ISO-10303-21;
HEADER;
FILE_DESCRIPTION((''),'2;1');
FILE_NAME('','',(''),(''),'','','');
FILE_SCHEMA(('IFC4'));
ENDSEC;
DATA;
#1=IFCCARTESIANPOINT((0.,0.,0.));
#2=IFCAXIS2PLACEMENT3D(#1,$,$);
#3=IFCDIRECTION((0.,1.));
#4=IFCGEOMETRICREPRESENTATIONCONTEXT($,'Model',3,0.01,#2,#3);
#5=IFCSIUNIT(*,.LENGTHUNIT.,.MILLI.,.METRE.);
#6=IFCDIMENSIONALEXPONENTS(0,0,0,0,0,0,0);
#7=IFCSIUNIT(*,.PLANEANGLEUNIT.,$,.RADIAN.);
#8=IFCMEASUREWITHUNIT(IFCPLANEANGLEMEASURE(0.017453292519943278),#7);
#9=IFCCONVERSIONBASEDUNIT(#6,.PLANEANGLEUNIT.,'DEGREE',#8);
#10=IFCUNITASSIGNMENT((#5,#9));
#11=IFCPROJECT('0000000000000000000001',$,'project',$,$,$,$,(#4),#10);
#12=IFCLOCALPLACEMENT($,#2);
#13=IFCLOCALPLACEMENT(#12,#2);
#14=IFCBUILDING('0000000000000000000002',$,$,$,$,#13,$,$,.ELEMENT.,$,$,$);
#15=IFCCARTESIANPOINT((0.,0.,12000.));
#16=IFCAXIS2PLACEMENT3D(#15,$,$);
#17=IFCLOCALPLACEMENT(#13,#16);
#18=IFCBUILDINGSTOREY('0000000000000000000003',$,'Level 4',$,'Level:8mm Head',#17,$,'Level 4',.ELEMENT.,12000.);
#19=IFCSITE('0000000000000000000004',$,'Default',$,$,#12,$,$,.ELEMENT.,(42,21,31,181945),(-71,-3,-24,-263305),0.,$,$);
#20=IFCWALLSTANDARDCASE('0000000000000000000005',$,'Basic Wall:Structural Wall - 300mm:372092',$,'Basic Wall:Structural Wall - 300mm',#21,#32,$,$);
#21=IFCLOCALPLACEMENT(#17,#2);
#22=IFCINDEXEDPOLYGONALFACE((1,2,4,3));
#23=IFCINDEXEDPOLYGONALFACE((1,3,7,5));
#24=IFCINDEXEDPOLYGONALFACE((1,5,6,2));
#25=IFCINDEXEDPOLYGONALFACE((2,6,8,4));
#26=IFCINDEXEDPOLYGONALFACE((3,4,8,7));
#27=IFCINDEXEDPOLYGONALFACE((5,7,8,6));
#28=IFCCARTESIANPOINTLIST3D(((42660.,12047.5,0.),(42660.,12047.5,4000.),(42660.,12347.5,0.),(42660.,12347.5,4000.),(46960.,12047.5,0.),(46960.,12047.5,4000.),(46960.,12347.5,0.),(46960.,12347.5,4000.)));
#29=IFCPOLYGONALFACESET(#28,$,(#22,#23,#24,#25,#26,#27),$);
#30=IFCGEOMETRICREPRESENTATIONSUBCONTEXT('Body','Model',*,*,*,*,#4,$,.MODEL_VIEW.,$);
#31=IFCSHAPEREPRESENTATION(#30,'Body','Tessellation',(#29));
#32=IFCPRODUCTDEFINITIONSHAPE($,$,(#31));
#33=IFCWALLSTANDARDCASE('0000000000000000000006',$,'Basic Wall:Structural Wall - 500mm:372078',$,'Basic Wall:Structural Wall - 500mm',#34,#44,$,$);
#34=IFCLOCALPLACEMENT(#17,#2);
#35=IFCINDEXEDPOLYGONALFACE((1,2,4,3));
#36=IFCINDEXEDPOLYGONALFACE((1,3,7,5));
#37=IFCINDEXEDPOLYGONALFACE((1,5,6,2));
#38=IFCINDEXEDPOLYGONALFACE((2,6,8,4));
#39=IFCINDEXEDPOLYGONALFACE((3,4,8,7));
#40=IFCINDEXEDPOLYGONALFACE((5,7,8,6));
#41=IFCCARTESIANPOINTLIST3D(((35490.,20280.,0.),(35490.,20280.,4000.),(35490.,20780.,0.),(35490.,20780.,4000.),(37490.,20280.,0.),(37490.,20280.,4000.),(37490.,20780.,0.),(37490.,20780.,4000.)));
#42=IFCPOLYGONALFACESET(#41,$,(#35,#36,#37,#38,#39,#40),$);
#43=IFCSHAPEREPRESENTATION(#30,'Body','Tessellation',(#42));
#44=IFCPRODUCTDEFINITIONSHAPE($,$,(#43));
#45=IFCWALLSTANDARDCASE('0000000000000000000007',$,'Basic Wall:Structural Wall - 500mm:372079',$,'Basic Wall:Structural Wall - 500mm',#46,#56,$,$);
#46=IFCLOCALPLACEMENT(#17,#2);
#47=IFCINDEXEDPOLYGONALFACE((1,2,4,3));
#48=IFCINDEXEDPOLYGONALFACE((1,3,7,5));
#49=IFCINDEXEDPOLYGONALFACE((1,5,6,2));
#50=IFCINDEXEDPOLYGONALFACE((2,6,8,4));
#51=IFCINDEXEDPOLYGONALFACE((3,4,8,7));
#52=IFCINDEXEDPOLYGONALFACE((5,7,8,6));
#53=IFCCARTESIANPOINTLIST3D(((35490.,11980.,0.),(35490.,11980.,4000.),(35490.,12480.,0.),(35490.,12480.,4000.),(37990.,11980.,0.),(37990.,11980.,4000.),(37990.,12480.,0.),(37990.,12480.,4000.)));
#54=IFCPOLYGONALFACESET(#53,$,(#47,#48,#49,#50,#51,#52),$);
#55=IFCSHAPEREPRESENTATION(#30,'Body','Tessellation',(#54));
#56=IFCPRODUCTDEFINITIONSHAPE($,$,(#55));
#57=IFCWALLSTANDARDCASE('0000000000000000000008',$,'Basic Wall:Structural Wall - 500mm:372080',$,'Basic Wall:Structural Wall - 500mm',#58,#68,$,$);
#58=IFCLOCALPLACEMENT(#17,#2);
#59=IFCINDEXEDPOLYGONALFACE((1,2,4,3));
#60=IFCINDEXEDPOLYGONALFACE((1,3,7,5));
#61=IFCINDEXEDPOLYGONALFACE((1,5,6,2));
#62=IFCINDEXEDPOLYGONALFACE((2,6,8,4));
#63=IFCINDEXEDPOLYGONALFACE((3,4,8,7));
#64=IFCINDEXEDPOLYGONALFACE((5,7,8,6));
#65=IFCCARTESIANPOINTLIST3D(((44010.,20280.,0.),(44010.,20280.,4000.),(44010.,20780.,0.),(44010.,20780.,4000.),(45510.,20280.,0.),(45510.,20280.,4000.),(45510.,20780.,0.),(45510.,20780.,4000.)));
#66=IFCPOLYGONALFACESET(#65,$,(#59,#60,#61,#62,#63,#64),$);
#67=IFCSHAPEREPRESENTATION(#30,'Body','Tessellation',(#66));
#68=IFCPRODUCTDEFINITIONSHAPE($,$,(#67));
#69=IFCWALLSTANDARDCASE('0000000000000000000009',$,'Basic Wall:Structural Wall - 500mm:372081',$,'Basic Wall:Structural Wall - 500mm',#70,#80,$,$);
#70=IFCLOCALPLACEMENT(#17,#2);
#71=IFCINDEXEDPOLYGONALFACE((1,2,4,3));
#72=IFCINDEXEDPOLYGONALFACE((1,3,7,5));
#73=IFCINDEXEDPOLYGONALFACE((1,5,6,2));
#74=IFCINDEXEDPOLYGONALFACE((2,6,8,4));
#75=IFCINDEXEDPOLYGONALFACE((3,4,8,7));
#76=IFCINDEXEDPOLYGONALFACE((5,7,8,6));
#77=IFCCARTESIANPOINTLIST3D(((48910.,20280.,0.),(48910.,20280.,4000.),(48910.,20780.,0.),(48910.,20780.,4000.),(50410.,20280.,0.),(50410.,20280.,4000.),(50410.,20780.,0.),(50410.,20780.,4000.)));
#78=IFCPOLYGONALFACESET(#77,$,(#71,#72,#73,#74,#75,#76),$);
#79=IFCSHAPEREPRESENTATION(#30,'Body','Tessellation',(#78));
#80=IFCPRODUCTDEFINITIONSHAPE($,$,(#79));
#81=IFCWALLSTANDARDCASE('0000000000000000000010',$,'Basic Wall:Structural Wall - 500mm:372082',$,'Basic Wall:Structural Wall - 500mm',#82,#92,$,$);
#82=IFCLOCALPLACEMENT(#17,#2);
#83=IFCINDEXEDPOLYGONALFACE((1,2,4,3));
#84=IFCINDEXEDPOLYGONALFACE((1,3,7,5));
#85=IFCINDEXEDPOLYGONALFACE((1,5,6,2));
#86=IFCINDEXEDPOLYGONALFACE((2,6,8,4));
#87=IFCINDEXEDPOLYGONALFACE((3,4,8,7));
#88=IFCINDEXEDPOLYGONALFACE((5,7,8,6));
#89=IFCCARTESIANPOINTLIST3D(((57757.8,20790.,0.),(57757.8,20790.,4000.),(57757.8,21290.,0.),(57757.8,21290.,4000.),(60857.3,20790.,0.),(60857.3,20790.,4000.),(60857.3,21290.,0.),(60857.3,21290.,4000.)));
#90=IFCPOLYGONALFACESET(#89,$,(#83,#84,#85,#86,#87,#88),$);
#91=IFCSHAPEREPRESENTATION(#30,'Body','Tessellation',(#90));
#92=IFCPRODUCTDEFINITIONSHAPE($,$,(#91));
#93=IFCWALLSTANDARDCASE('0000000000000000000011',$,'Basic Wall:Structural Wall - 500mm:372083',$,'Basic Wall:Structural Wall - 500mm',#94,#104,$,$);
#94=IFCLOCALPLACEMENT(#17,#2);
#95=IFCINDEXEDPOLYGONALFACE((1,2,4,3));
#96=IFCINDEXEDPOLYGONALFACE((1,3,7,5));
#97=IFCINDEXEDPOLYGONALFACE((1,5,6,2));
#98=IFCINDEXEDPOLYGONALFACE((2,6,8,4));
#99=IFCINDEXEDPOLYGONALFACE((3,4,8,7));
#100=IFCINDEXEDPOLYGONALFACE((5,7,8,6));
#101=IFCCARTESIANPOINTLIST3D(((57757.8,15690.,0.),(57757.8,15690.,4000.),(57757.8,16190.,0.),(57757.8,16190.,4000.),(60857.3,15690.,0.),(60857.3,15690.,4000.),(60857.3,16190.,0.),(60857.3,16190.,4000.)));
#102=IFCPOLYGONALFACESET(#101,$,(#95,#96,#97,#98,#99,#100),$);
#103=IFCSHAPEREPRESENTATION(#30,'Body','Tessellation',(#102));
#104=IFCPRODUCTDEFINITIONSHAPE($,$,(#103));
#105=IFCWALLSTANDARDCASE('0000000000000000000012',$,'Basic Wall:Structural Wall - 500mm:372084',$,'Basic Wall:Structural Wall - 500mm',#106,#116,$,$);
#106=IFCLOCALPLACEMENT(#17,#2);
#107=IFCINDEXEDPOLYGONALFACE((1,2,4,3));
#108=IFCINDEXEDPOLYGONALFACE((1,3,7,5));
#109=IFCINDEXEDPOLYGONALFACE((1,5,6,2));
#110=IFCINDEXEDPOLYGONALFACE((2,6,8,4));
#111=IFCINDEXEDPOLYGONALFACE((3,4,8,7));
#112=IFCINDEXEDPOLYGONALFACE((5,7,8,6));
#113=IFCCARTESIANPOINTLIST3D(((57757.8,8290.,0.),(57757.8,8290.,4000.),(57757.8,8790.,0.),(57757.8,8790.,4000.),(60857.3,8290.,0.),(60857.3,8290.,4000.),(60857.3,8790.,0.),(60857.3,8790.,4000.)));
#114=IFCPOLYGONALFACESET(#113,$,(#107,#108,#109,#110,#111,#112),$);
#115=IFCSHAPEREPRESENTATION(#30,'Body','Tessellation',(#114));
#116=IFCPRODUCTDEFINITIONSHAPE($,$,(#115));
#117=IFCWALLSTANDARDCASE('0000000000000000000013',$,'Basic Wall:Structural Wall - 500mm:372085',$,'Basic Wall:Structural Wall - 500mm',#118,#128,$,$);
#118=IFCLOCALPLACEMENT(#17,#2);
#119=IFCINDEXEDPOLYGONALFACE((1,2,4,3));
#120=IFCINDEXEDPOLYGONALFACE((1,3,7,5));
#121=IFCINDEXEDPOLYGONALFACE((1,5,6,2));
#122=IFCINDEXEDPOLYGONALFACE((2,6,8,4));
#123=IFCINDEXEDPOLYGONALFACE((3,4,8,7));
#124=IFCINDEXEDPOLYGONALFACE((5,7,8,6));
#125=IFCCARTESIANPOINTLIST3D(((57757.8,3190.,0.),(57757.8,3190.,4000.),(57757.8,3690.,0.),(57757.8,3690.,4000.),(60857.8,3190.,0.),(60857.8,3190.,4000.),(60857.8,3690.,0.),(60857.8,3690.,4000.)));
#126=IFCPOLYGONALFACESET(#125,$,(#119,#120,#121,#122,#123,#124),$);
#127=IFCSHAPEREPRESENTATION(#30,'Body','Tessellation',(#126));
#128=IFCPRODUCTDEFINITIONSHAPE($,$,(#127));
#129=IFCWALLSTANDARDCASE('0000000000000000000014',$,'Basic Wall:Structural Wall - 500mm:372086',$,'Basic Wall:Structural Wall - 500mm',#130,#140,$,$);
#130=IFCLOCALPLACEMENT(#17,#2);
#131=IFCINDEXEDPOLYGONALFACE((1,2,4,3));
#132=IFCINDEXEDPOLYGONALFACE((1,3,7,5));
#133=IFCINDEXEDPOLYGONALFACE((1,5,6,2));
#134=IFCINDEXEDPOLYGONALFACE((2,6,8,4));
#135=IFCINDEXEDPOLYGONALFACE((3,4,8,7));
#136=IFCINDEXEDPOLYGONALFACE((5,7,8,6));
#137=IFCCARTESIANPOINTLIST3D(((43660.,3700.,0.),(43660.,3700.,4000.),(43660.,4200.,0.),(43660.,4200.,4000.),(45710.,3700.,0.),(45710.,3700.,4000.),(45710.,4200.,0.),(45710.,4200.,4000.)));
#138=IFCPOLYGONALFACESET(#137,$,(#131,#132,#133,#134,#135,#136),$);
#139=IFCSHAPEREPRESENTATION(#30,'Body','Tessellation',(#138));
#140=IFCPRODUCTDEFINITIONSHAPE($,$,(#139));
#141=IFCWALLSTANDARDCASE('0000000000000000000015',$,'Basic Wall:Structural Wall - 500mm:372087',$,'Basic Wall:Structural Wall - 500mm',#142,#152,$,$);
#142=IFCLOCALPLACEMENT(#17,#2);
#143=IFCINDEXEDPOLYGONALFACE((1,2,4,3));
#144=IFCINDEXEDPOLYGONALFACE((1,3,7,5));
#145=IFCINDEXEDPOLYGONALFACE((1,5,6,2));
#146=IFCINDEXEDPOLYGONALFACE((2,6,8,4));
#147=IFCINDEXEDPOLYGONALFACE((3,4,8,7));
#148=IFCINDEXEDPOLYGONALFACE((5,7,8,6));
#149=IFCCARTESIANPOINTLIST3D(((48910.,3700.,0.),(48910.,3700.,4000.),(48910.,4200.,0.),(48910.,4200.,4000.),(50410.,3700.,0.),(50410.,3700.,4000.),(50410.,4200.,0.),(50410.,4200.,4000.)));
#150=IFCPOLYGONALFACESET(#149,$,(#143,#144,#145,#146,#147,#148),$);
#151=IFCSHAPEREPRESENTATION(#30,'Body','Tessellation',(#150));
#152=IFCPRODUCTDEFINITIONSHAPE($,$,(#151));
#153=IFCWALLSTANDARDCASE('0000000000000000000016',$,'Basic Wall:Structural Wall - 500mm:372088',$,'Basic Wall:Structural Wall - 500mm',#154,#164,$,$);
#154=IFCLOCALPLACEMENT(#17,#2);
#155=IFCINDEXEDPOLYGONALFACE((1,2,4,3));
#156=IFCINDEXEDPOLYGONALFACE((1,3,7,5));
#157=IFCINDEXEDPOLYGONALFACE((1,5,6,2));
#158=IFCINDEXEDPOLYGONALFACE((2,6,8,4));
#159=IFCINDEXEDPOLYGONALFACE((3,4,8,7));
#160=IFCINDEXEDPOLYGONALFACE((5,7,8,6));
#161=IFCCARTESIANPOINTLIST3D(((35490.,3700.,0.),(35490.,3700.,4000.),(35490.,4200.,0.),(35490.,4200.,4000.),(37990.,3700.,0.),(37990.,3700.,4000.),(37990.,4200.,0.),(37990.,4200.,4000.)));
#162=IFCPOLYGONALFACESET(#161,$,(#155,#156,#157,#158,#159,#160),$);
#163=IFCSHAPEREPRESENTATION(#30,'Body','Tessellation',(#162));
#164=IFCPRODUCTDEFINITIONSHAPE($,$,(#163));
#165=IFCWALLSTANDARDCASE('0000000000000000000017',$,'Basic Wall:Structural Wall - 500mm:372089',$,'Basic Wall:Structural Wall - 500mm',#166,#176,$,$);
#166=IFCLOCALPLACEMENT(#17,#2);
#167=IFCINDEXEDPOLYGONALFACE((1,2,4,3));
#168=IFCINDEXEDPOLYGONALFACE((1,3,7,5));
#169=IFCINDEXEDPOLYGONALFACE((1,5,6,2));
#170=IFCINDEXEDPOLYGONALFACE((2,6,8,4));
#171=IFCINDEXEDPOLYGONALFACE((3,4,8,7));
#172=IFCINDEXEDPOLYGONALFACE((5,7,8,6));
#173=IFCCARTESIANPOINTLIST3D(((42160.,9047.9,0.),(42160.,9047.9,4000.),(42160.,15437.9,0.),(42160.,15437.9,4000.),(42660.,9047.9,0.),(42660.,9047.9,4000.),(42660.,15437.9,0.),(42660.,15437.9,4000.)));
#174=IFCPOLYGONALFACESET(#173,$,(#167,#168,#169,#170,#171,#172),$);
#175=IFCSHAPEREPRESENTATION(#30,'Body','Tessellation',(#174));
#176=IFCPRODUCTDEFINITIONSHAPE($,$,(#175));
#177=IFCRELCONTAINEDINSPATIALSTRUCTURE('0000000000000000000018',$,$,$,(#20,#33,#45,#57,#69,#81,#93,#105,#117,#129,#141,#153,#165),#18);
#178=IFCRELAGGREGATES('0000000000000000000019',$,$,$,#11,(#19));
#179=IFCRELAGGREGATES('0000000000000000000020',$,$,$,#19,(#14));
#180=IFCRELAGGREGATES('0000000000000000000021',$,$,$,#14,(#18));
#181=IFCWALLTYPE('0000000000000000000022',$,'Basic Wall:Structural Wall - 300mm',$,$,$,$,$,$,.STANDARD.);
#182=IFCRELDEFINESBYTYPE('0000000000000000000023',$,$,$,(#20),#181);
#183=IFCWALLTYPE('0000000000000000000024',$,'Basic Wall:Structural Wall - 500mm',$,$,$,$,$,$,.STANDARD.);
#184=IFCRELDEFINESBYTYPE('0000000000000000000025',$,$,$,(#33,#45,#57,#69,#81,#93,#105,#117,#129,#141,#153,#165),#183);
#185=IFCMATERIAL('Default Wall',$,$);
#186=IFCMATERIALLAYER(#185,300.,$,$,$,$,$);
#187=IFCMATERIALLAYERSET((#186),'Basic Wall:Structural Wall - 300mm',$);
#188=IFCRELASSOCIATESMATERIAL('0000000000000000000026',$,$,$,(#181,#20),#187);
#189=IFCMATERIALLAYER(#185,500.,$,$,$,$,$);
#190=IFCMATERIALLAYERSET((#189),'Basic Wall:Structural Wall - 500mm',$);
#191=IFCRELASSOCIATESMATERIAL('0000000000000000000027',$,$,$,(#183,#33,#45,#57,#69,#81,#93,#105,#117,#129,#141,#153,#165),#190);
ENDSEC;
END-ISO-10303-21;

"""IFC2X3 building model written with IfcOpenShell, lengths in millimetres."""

from ifc_helpers import new_model, entity, si_unit, converted_unit, direction, frame, frame_2d, origin, place, context, subcontext, project, spatial, rectangle, extrude, material, layer, layer_set, layer_usage, type_object, element, save


model = new_model("IFC2X3")

# Units and contexts
model_context = context("Model", 3, precision=0.01, world=origin(), true_north=direction((0.0, 1.0)))
body_context = subcontext(model_context, "Body", "Model", "MODEL_VIEW")
ifc_project = project(units=[si_unit("LENGTHUNIT", "METRE", prefix="MILLI"), converted_unit("PLANEANGLEUNIT", "DEGREE", entity("IfcPlaneAngleMeasure", 0.017453292519943278), si_unit("PLANEANGLEUNIT", "RADIAN"), dimensions=[0, 0, 0, 0, 0, 0, 0])], contexts=[model_context])

# Site, building, storey
site_placement = place(None, origin())
site = spatial("IfcSite", under=ifc_project, at=site_placement, Name="Default", CompositionType="ELEMENT", RefLatitude=(42, 21, 31, 181945), RefLongitude=(-71, -3, -24, -263305), RefElevation=0.0)
building_placement = place(site_placement, origin())
building = spatial("IfcBuilding", under=site, at=building_placement, CompositionType="ELEMENT")
storey_placement = place(building_placement, frame((0.0, 0.0, 12000.0)))
storey = spatial("IfcBuildingStorey", under=building, at=storey_placement, Name="Level 4", ObjectType="Level:8mm Head", LongName="Level 4", CompositionType="ELEMENT", Elevation=12000.0)

# Walls
ifc_material = material(Name="Default Wall")
ifc_layer_1 = layer(ifc_material, 300.0)
ifc_layer_set_1 = layer_set([ifc_layer_1], Name="Basic Wall:Structural Wall - 300mm")
ifc_layer_usage_1 = layer_usage(ifc_layer_set_1, "AXIS2", "NEGATIVE", 150.0)
wall_type_1 = type_object("IfcWallType", Name="Basic Wall:Structural Wall - 300mm", PredefinedType="STANDARD", material=ifc_layer_set_1)
wall_1_placement = place(storey_placement, frame((42660.0, 12197.5, 0.0)))
element("IfcWallStandardCase", 1, at=wall_1_placement, inside=storey, type_object=wall_type_1, material=ifc_layer_usage_1, Name="Basic Wall:Structural Wall - 300mm:372092", ObjectType="Basic Wall:Structural Wall - 300mm", context=body_context, shape_type="SweptSolid", body=[
    extrude(rectangle(XDim=4300.0, YDim=300.0, at=frame_2d((2150.0, 0.0), x_axis=(-1.0, 0.0))), origin(), (0.0, 0.0, 1.0), 4000.0),
])
ifc_layer_2 = layer(ifc_material, 500.0)
ifc_layer_set_2 = layer_set([ifc_layer_2], Name="Basic Wall:Structural Wall - 500mm")
ifc_layer_usage_2 = layer_usage(ifc_layer_set_2, "AXIS2", "NEGATIVE", 250.0)
wall_type_2 = type_object("IfcWallType", Name="Basic Wall:Structural Wall - 500mm", PredefinedType="STANDARD", material=ifc_layer_set_2)
wall_2_placement = place(storey_placement, frame((35490.0, 20530.0, 0.0)))
element("IfcWallStandardCase", 2, at=wall_2_placement, inside=storey, type_object=wall_type_2, material=ifc_layer_usage_2, Name="Basic Wall:Structural Wall - 500mm:372078", ObjectType="Basic Wall:Structural Wall - 500mm", context=body_context, shape_type="SweptSolid", body=[
    extrude(rectangle(XDim=2000.0, YDim=500.0, at=frame_2d((1000.0, 0.0), x_axis=(-1.0, 0.0))), origin(), (0.0, 0.0, 1.0), 4000.0),
])
ifc_layer_usage_3 = layer_usage(ifc_layer_set_2, "AXIS2", "NEGATIVE", 250.0)
wall_3_placement = place(storey_placement, frame((35490.0, 12230.0, 0.0)))
element("IfcWallStandardCase", 3, at=wall_3_placement, inside=storey, type_object=wall_type_2, material=ifc_layer_usage_3, Name="Basic Wall:Structural Wall - 500mm:372079", ObjectType="Basic Wall:Structural Wall - 500mm", context=body_context, shape_type="SweptSolid", body=[
    extrude(rectangle(XDim=2500.0, YDim=500.0, at=frame_2d((1250.0, 0.0), x_axis=(-1.0, 0.0))), origin(), (0.0, 0.0, 1.0), 4000.0),
])
ifc_layer_usage_4 = layer_usage(ifc_layer_set_2, "AXIS2", "NEGATIVE", 250.0)
wall_4_placement = place(storey_placement, frame((44010.0, 20530.0, 0.0)))
element("IfcWallStandardCase", 4, at=wall_4_placement, inside=storey, type_object=wall_type_2, material=ifc_layer_usage_4, Name="Basic Wall:Structural Wall - 500mm:372080", ObjectType="Basic Wall:Structural Wall - 500mm", context=body_context, shape_type="SweptSolid", body=[
    extrude(rectangle(XDim=1500.0, YDim=500.0, at=frame_2d((750.0, 0.0), x_axis=(-1.0, 0.0))), origin(), (0.0, 0.0, 1.0), 4000.0),
])
ifc_layer_usage_5 = layer_usage(ifc_layer_set_2, "AXIS2", "NEGATIVE", 250.0)
wall_5_placement = place(storey_placement, frame((48910.0, 20530.0, 0.0)))
element("IfcWallStandardCase", 5, at=wall_5_placement, inside=storey, type_object=wall_type_2, material=ifc_layer_usage_5, Name="Basic Wall:Structural Wall - 500mm:372081", ObjectType="Basic Wall:Structural Wall - 500mm", context=body_context, shape_type="SweptSolid", body=[
    extrude(rectangle(XDim=1500.0, YDim=500.0, at=frame_2d((750.0, 0.0), x_axis=(-1.0, 0.0))), origin(), (0.0, 0.0, 1.0), 4000.0),
])
ifc_layer_usage_6 = layer_usage(ifc_layer_set_2, "AXIS2", "NEGATIVE", 250.0)
wall_6_placement = place(storey_placement, frame((57757.8, 21040.0, 0.0)))
element("IfcWallStandardCase", 6, at=wall_6_placement, inside=storey, type_object=wall_type_2, material=ifc_layer_usage_6, Name="Basic Wall:Structural Wall - 500mm:372082", ObjectType="Basic Wall:Structural Wall - 500mm", context=body_context, shape_type="SweptSolid", body=[
    extrude(rectangle(XDim=3099.5, YDim=500.0, at=frame_2d((1549.8, 0.0), x_axis=(-1.0, 0.0))), origin(), (0.0, 0.0, 1.0), 4000.0),
])
ifc_layer_usage_7 = layer_usage(ifc_layer_set_2, "AXIS2", "NEGATIVE", 250.0)
wall_7_placement = place(storey_placement, frame((57757.8, 15940.0, 0.0)))
element("IfcWallStandardCase", 7, at=wall_7_placement, inside=storey, type_object=wall_type_2, material=ifc_layer_usage_7, Name="Basic Wall:Structural Wall - 500mm:372083", ObjectType="Basic Wall:Structural Wall - 500mm", context=body_context, shape_type="SweptSolid", body=[
    extrude(rectangle(XDim=3099.5, YDim=500.0, at=frame_2d((1549.8, 0.0), x_axis=(-1.0, 0.0))), origin(), (0.0, 0.0, 1.0), 4000.0),
])
ifc_layer_usage_8 = layer_usage(ifc_layer_set_2, "AXIS2", "NEGATIVE", 250.0)
wall_8_placement = place(storey_placement, frame((57757.8, 8540.0, 0.0)))
element("IfcWallStandardCase", 8, at=wall_8_placement, inside=storey, type_object=wall_type_2, material=ifc_layer_usage_8, Name="Basic Wall:Structural Wall - 500mm:372084", ObjectType="Basic Wall:Structural Wall - 500mm", context=body_context, shape_type="SweptSolid", body=[
    extrude(rectangle(XDim=3099.5, YDim=500.0, at=frame_2d((1549.8, 0.0), x_axis=(-1.0, 0.0))), origin(), (0.0, 0.0, 1.0), 4000.0),
])
ifc_layer_usage_9 = layer_usage(ifc_layer_set_2, "AXIS2", "NEGATIVE", 250.0)
wall_9_placement = place(storey_placement, frame((57757.8, 3440.0, 0.0)))
element("IfcWallStandardCase", 9, at=wall_9_placement, inside=storey, type_object=wall_type_2, material=ifc_layer_usage_9, Name="Basic Wall:Structural Wall - 500mm:372085", ObjectType="Basic Wall:Structural Wall - 500mm", context=body_context, shape_type="SweptSolid", body=[
    extrude(rectangle(XDim=3100.0, YDim=500.0, at=frame_2d((1550.0, 0.0), x_axis=(-1.0, 0.0))), origin(), (0.0, 0.0, 1.0), 4000.0),
])
ifc_layer_usage_10 = layer_usage(ifc_layer_set_2, "AXIS2", "NEGATIVE", 250.0)
wall_10_placement = place(storey_placement, frame((43660.0, 3950.0, 0.0)))
element("IfcWallStandardCase", 10, at=wall_10_placement, inside=storey, type_object=wall_type_2, material=ifc_layer_usage_10, Name="Basic Wall:Structural Wall - 500mm:372086", ObjectType="Basic Wall:Structural Wall - 500mm", context=body_context, shape_type="SweptSolid", body=[
    extrude(rectangle(XDim=2050.0, YDim=500.0, at=frame_2d((1025.0, 0.0), x_axis=(-1.0, 0.0))), origin(), (0.0, 0.0, 1.0), 4000.0),
])
ifc_layer_usage_11 = layer_usage(ifc_layer_set_2, "AXIS2", "NEGATIVE", 250.0)
wall_11_placement = place(storey_placement, frame((48910.0, 3950.0, 0.0)))
element("IfcWallStandardCase", 11, at=wall_11_placement, inside=storey, type_object=wall_type_2, material=ifc_layer_usage_11, Name="Basic Wall:Structural Wall - 500mm:372087", ObjectType="Basic Wall:Structural Wall - 500mm", context=body_context, shape_type="SweptSolid", body=[
    extrude(rectangle(XDim=1500.0, YDim=500.0, at=frame_2d((750.0, 0.0), x_axis=(-1.0, 0.0))), origin(), (0.0, 0.0, 1.0), 4000.0),
])
ifc_layer_usage_12 = layer_usage(ifc_layer_set_2, "AXIS2", "NEGATIVE", 250.0)
wall_12_placement = place(storey_placement, frame((35490.0, 3950.0, 0.0)))
element("IfcWallStandardCase", 12, at=wall_12_placement, inside=storey, type_object=wall_type_2, material=ifc_layer_usage_12, Name="Basic Wall:Structural Wall - 500mm:372088", ObjectType="Basic Wall:Structural Wall - 500mm", context=body_context, shape_type="SweptSolid", body=[
    extrude(rectangle(XDim=2500.0, YDim=500.0, at=frame_2d((1250.0, 0.0), x_axis=(-1.0, 0.0))), origin(), (0.0, 0.0, 1.0), 4000.0),
])
ifc_layer_usage_13 = layer_usage(ifc_layer_set_2, "AXIS2", "NEGATIVE", 250.0)
wall_13_placement = place(storey_placement, frame((42410.0, 15437.9, 0.0), z_axis=(0.0, 0.0, 1.0), x_axis=(0.0, -1.0, 0.0)))
element("IfcWallStandardCase", 13, at=wall_13_placement, inside=storey, type_object=wall_type_2, material=ifc_layer_usage_13, Name="Basic Wall:Structural Wall - 500mm:372089", ObjectType="Basic Wall:Structural Wall - 500mm", context=body_context, shape_type="SweptSolid", body=[
    extrude(rectangle(XDim=6390.0, YDim=500.0, at=frame_2d((3195.0, 0.0), x_axis=(-1.0, 0.0))), origin(), (0.0, 0.0, 1.0), 4000.0),
])

save(model, "model.ifc")
